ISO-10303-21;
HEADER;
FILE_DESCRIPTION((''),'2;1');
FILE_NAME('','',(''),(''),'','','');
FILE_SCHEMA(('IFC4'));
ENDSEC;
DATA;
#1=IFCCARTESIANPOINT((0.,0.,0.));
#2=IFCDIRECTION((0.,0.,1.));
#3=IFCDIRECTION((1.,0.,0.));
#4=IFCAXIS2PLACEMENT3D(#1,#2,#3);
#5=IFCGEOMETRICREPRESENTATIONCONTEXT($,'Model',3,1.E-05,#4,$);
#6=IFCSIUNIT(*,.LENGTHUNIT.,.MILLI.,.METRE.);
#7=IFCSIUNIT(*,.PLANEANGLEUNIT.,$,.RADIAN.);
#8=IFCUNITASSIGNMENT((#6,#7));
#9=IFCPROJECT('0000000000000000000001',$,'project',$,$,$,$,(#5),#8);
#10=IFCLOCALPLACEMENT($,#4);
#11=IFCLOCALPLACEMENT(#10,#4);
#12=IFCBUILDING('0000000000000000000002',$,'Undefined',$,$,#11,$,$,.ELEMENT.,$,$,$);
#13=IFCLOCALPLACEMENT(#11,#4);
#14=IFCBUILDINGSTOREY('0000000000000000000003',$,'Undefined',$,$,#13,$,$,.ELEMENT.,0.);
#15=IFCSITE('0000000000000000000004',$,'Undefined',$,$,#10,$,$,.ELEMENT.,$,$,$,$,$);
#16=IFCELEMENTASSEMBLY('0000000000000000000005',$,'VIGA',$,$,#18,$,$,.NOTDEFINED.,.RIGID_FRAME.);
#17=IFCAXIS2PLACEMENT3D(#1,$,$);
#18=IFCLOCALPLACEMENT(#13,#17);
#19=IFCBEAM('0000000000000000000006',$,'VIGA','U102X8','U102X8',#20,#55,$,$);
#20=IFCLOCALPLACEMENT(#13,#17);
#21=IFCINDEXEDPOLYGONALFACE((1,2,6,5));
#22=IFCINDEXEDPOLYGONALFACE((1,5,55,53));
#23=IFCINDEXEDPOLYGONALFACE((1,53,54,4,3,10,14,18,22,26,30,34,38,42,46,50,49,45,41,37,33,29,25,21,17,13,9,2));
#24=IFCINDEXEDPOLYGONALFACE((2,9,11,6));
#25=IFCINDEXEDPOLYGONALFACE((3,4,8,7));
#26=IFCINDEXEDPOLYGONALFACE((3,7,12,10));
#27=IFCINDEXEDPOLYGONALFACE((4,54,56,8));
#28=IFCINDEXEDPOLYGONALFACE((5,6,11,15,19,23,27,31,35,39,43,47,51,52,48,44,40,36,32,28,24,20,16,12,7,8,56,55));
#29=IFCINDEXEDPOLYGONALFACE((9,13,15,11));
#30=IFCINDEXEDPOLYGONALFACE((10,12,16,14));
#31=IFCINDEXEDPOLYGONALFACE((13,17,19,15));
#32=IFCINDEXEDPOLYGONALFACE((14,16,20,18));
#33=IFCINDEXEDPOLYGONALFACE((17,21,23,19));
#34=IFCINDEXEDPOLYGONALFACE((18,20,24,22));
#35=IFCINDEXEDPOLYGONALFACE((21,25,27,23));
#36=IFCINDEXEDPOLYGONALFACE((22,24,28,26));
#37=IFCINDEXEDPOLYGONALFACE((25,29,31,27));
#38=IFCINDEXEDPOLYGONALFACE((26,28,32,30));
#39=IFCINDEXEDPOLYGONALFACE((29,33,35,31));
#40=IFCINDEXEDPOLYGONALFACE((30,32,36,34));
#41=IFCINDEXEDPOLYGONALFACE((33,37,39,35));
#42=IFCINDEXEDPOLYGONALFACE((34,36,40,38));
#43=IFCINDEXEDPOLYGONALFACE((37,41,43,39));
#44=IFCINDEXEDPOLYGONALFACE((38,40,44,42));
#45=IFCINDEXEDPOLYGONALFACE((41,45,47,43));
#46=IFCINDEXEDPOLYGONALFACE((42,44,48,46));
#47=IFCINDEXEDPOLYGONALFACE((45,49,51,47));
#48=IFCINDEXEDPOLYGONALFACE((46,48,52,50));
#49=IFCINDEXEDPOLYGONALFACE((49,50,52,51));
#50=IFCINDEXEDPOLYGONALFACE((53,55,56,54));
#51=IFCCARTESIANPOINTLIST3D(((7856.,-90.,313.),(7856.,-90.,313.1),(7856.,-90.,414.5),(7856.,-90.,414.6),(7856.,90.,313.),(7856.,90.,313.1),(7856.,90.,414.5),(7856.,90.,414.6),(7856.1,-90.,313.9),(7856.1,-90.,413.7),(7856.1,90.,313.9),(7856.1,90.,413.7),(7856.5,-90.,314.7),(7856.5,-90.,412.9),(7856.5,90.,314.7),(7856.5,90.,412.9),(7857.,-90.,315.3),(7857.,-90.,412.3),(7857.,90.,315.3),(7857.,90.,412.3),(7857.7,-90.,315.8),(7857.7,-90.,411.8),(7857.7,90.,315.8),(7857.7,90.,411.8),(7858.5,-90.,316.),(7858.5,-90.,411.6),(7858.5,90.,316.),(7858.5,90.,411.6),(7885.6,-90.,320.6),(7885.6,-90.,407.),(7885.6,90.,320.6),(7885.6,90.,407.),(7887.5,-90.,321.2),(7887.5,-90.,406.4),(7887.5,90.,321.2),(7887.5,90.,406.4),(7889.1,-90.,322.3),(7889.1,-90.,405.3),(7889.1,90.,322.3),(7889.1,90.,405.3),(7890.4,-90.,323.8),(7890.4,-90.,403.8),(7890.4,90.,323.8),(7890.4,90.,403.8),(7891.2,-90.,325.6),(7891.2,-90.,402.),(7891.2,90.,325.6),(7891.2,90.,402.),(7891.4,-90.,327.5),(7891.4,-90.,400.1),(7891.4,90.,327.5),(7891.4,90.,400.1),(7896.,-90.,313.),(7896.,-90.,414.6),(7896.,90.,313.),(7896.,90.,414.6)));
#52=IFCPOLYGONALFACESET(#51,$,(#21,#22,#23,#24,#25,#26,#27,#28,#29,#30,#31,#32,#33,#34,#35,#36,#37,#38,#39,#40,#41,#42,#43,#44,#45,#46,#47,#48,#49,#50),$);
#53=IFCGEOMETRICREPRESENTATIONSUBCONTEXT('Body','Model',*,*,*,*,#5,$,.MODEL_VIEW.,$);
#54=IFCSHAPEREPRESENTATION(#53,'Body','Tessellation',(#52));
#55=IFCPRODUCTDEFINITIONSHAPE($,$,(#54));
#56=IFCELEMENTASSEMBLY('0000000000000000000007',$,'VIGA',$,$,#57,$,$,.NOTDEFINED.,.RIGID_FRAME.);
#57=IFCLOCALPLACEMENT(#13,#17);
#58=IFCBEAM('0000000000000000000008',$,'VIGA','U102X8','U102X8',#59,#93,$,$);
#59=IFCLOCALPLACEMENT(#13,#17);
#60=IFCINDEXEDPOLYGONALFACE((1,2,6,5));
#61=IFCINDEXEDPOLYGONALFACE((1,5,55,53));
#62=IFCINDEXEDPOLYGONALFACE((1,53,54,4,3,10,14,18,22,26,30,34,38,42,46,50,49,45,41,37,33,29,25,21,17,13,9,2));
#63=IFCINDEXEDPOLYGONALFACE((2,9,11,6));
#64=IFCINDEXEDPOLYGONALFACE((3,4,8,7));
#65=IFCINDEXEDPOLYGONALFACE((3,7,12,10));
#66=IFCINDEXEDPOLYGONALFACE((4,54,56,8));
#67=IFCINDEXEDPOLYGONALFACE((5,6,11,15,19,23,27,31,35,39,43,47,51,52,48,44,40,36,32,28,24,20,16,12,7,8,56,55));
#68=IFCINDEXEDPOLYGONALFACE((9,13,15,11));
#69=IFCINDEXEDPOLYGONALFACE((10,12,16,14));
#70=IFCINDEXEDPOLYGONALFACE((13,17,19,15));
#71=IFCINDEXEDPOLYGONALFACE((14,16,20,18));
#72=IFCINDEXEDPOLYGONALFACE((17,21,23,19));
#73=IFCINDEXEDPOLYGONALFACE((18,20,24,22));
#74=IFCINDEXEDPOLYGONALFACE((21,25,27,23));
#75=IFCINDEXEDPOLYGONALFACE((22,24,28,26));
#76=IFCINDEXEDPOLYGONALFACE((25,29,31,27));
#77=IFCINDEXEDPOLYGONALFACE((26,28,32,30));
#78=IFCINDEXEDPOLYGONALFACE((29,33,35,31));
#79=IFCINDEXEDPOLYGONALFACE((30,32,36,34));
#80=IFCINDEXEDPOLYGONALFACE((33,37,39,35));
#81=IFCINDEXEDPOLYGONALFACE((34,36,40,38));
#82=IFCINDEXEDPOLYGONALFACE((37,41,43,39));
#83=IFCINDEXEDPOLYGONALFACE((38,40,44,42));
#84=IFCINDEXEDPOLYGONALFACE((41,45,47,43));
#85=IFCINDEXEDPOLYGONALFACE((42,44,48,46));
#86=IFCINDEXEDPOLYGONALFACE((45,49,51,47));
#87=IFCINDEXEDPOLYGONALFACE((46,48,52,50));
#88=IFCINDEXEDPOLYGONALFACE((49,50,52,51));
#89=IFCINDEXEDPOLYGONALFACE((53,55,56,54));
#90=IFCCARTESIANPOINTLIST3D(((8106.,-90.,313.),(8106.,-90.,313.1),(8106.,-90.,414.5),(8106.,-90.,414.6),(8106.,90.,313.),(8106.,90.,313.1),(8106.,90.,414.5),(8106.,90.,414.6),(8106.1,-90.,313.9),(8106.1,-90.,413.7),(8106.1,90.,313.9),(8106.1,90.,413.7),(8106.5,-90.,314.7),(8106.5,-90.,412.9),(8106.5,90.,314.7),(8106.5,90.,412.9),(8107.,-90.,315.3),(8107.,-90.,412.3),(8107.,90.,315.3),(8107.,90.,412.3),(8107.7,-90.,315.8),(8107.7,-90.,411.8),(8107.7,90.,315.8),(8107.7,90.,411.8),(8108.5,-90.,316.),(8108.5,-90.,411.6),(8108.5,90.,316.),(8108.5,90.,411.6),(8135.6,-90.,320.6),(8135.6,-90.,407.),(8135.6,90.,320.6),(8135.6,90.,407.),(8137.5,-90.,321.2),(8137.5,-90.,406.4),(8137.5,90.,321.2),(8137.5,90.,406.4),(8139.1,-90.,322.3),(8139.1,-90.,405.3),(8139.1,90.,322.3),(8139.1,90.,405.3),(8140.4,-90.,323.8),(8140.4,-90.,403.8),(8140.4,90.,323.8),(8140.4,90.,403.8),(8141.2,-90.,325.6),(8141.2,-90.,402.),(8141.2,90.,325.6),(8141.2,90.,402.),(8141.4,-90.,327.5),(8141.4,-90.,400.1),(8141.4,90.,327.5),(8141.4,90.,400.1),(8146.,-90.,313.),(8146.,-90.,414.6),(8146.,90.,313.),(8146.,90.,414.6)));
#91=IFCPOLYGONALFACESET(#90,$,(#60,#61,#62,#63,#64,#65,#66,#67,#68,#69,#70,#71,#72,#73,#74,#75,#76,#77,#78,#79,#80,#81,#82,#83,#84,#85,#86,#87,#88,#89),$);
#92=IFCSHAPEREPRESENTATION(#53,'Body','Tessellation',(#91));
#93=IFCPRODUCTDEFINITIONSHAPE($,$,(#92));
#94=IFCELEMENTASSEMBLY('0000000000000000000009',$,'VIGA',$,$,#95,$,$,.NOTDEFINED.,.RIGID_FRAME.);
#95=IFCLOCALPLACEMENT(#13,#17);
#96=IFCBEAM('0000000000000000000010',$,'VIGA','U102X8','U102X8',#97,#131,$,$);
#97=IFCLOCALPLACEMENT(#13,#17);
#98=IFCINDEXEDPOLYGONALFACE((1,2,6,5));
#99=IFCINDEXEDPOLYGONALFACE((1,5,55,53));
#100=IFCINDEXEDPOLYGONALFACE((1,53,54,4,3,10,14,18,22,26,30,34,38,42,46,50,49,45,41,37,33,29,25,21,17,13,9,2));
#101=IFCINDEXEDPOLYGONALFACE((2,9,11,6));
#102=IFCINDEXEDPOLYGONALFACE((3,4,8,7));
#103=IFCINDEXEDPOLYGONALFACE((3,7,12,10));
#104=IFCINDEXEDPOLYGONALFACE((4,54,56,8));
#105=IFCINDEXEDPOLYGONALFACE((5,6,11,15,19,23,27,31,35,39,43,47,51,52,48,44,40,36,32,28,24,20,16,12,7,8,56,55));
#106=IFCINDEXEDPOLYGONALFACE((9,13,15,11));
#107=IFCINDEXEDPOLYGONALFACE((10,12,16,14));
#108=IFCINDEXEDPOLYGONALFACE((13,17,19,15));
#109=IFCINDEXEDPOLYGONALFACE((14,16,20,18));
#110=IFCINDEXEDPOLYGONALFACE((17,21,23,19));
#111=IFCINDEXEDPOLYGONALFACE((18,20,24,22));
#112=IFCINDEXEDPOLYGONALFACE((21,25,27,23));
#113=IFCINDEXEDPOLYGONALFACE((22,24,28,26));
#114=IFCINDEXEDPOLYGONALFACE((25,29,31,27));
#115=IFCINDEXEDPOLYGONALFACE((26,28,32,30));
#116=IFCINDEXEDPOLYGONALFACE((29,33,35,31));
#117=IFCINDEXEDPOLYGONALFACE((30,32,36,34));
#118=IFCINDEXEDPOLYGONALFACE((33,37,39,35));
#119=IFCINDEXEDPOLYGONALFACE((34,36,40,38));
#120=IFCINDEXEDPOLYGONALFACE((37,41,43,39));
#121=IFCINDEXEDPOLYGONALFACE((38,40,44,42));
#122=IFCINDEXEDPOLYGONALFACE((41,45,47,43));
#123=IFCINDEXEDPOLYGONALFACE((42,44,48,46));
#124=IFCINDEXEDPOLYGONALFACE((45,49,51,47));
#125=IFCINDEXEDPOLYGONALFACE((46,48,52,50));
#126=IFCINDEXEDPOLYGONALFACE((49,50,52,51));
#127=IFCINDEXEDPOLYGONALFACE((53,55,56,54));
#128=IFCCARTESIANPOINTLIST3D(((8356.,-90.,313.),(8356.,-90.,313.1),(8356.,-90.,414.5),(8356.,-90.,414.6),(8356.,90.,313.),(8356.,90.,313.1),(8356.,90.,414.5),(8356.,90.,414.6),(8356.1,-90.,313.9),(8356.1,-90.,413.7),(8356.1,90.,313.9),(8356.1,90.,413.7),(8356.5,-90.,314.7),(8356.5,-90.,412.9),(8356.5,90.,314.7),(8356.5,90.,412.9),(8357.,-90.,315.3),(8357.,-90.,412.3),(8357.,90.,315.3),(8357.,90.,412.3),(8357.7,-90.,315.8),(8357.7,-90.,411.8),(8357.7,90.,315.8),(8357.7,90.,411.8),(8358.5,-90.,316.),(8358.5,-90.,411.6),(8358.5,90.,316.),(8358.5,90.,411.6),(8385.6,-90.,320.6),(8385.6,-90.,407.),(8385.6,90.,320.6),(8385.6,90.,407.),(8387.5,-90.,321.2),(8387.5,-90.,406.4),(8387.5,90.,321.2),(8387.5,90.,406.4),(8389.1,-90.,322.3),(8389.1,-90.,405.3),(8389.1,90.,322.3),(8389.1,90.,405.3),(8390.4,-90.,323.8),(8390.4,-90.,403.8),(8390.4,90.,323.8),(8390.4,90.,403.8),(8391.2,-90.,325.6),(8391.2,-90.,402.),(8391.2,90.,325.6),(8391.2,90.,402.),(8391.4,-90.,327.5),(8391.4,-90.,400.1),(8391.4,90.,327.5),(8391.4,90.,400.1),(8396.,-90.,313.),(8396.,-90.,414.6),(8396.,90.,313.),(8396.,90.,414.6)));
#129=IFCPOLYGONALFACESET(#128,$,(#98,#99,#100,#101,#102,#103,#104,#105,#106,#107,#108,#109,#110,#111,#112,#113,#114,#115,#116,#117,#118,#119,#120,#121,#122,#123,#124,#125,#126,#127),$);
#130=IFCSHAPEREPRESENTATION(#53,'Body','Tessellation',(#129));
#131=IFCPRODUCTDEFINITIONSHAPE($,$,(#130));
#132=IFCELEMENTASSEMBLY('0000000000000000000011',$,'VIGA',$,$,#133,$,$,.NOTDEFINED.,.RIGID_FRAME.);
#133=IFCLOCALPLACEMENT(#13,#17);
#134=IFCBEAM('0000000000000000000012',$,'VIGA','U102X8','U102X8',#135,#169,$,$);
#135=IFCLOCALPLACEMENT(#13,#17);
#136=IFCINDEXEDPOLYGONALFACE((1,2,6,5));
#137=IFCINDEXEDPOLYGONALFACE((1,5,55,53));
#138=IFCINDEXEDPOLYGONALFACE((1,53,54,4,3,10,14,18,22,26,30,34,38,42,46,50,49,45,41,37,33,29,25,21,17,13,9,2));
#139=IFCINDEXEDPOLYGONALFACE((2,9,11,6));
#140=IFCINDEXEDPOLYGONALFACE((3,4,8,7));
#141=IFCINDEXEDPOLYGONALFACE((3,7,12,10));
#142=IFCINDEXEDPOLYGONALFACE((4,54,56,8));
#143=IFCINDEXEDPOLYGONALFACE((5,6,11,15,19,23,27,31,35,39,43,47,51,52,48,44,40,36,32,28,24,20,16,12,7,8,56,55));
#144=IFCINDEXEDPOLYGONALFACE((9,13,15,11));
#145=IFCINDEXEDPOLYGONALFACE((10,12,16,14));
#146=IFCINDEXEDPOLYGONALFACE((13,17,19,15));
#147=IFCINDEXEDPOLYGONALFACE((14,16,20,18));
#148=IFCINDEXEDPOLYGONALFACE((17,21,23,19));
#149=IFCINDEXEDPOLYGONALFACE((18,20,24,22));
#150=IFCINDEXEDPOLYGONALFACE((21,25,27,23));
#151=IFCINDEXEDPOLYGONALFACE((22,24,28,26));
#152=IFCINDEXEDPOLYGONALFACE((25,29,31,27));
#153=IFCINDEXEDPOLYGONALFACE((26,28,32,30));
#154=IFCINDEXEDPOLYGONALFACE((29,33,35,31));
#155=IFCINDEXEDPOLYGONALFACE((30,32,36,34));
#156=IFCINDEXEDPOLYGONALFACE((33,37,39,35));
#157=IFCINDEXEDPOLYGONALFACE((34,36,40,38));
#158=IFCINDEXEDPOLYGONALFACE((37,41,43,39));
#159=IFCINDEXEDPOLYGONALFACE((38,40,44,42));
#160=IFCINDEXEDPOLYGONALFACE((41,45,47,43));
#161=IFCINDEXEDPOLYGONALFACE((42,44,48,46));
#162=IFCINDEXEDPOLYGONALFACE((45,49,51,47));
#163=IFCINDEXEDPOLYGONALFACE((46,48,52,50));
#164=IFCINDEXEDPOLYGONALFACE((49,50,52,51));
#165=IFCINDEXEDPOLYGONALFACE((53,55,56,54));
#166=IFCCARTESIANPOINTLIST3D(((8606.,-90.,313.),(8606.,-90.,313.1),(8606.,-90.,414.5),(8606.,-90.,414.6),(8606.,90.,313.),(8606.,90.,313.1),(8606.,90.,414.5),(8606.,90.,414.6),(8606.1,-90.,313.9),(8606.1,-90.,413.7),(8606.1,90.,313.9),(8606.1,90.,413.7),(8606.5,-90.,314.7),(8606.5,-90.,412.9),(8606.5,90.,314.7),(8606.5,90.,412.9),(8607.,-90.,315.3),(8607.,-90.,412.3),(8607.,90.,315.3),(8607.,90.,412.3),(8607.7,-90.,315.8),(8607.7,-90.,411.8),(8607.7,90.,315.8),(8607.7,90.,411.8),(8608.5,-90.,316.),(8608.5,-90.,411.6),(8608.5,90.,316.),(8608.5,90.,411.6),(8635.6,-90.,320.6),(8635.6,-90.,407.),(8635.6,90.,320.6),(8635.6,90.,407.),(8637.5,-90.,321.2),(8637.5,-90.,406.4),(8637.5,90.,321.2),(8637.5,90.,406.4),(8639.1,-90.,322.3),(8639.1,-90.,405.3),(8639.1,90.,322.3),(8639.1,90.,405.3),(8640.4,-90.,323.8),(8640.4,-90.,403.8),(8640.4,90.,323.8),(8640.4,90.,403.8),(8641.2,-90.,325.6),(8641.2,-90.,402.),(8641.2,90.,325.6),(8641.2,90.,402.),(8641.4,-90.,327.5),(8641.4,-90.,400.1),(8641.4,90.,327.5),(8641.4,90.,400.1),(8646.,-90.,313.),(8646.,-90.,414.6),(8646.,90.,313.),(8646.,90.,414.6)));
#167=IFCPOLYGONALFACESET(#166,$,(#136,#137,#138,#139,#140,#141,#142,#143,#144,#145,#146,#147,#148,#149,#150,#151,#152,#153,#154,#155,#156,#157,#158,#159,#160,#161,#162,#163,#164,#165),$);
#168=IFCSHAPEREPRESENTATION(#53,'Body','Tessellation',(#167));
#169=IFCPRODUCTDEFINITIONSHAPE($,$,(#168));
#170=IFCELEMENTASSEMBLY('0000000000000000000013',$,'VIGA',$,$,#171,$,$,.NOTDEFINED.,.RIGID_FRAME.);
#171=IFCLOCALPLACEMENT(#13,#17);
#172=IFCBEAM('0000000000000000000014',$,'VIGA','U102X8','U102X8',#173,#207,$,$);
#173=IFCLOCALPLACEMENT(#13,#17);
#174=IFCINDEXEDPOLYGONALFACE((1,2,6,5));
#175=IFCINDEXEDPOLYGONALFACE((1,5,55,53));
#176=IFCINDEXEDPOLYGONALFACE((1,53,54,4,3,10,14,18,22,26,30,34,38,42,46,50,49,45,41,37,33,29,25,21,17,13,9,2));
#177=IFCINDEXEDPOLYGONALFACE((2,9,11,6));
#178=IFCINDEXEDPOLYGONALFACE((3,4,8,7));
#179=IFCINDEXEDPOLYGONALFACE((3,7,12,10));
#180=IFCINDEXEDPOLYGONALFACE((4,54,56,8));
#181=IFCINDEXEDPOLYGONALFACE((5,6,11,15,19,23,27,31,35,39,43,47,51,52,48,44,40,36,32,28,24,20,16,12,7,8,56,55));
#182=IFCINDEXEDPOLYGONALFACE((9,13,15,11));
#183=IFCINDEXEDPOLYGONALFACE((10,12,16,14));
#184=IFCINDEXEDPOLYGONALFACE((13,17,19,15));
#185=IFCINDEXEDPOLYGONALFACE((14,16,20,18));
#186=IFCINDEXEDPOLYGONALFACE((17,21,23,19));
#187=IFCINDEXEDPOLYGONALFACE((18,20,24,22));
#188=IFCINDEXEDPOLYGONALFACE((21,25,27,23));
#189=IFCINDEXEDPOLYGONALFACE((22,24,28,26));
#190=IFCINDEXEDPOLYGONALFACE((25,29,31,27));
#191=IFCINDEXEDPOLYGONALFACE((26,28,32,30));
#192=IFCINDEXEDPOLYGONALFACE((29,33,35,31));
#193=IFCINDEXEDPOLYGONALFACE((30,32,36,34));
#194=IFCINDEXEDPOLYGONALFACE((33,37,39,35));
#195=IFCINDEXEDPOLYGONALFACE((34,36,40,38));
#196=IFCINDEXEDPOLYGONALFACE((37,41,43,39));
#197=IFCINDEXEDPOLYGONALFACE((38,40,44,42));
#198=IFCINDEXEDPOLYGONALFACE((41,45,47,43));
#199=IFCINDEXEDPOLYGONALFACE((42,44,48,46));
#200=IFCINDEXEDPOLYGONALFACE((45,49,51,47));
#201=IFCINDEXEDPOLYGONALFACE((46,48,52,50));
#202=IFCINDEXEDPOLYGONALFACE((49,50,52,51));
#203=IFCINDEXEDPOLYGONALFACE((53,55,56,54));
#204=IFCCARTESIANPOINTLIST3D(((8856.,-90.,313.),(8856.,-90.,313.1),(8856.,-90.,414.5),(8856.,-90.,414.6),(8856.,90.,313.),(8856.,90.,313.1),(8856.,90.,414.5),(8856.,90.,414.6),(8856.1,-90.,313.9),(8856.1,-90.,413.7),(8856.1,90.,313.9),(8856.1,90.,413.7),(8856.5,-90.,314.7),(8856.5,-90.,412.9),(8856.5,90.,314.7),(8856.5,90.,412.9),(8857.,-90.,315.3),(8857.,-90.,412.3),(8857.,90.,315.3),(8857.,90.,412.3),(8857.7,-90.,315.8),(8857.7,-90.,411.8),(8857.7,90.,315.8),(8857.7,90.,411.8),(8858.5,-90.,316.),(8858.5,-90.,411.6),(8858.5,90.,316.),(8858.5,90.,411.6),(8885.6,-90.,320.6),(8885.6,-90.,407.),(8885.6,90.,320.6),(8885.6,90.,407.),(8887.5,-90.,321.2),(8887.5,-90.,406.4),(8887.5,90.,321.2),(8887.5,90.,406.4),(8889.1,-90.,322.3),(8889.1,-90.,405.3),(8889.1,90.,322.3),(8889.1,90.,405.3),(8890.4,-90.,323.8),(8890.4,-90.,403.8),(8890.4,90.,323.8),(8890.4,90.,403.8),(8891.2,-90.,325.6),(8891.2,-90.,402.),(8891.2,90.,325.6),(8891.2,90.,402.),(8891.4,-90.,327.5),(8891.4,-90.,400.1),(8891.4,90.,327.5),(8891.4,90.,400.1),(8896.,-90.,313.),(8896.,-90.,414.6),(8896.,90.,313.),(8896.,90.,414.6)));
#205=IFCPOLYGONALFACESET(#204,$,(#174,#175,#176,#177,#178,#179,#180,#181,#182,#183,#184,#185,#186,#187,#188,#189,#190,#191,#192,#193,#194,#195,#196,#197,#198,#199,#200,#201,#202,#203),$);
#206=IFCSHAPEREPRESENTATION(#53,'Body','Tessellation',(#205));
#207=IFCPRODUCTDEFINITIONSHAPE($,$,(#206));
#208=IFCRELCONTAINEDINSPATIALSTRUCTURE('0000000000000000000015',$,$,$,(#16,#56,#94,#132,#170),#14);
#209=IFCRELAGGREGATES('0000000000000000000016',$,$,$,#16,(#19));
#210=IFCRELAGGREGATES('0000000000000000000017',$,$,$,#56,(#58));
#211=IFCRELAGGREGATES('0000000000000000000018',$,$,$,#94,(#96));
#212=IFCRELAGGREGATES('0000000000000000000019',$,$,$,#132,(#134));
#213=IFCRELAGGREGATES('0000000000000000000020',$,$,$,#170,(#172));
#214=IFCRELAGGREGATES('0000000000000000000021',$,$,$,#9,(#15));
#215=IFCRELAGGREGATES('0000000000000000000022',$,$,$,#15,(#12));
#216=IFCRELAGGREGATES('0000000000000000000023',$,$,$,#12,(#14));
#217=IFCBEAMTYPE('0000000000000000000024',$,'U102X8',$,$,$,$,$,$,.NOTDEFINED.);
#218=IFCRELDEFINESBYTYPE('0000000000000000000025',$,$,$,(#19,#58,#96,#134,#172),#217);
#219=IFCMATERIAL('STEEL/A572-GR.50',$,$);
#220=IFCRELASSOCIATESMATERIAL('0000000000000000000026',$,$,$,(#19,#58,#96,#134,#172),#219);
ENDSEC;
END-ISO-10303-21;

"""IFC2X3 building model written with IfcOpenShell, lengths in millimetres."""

from ifc_helpers import new_model, si_unit, frame, origin_with_axes, origin_2d_with_axis, place, context, subcontext, project, spatial, u_section, extrude, material, type_object, element, aggregate, save


model = new_model("IFC2X3")

# Units and contexts
model_context = context("Model", 3, precision=1e-05, world=origin_with_axes())
body_context = subcontext(model_context, "Body", "Model", "MODEL_VIEW")
ifc_project = project(units=[si_unit("LENGTHUNIT", "METRE", prefix="MILLI"), si_unit("PLANEANGLEUNIT", "RADIAN")], contexts=[model_context])

# Site, building, storey
site_placement = place(None, origin_with_axes())
site = spatial("IfcSite", under=ifc_project, at=site_placement, Name="Undefined", CompositionType="ELEMENT")
building_placement = place(site_placement, origin_with_axes())
building = spatial("IfcBuilding", under=site, at=building_placement, Name="Undefined", CompositionType="ELEMENT")
storey_placement = place(building_placement, origin_with_axes())
storey = spatial("IfcBuildingStorey", under=building, at=storey_placement, Name="Undefined", CompositionType="ELEMENT", Elevation=0.0)

# Element assemblies, beams
ifc_material_1 = material(Name="STEEL/A572-GR.50")
beam_type = type_object("IfcBeamType", Name="U102X8", PredefinedType="NOTDEFINED")
assembly_1_placement = place(storey_placement, origin_with_axes())
assembly_1 = element("IfcElementAssembly", 1, at=assembly_1_placement, inside=storey, Name="VIGA", AssemblyPlace="NOTDEFINED", PredefinedType="RIGID_FRAME")
beam_1_placement = place(assembly_1_placement, frame((7876.0, 90.0, 363.8), z_axis=(0.0, 0.0, 1.0), x_axis=(0.0, -1.0, 0.0)))
beam_1 = element("IfcBeam", 2, at=beam_1_placement, type_object=beam_type, material=ifc_material_1, Name="VIGA", Description="U102X8", ObjectType="U102X8", context=body_context, shape_type="SweptSolid", body=[
    extrude(u_section(Depth=101.6, FlangeWidth=40.0, WebThickness=4.6, FlangeThickness=6.0, FilletRadius=7.0, EdgeRadius=3.0, FlangeSlope=0.16839, at=origin_2d_with_axis()), frame((180.0, 0.0, 0.0), z_axis=(-1.0, 0.0, 0.0), x_axis=(0.0, -1.0, 0.0)), (0.0, 0.0, 1.0), 180.0),
])
aggregate(assembly_1, [beam_1])
assembly_2_placement = place(storey_placement, origin_with_axes())
assembly_2 = element("IfcElementAssembly", 3, at=assembly_2_placement, inside=storey, Name="VIGA", AssemblyPlace="NOTDEFINED", PredefinedType="RIGID_FRAME")
beam_2_placement = place(assembly_2_placement, frame((8126.0, 90.0, 363.8), z_axis=(0.0, 0.0, 1.0), x_axis=(0.0, -1.0, 0.0)))
beam_2 = element("IfcBeam", 4, at=beam_2_placement, type_object=beam_type, material=ifc_material_1, Name="VIGA", Description="U102X8", ObjectType="U102X8", context=body_context, shape_type="SweptSolid", body=[
    extrude(u_section(Depth=101.6, FlangeWidth=40.0, WebThickness=4.6, FlangeThickness=6.0, FilletRadius=7.0, EdgeRadius=3.0, FlangeSlope=0.16839, at=origin_2d_with_axis()), frame((180.0, 0.0, 0.0), z_axis=(-1.0, 0.0, 0.0), x_axis=(0.0, -1.0, 0.0)), (0.0, 0.0, 1.0), 180.0),
])
aggregate(assembly_2, [beam_2])
assembly_3_placement = place(storey_placement, origin_with_axes())
assembly_3 = element("IfcElementAssembly", 5, at=assembly_3_placement, inside=storey, Name="VIGA", AssemblyPlace="NOTDEFINED", PredefinedType="RIGID_FRAME")
beam_3_placement = place(assembly_3_placement, frame((8376.0, 90.0, 363.8), z_axis=(0.0, 0.0, 1.0), x_axis=(0.0, -1.0, 0.0)))
beam_3 = element("IfcBeam", 6, at=beam_3_placement, type_object=beam_type, material=ifc_material_1, Name="VIGA", Description="U102X8", ObjectType="U102X8", context=body_context, shape_type="SweptSolid", body=[
    extrude(u_section(Depth=101.6, FlangeWidth=40.0, WebThickness=4.6, FlangeThickness=6.0, FilletRadius=7.0, EdgeRadius=3.0, FlangeSlope=0.16839, at=origin_2d_with_axis()), frame((180.0, 0.0, 0.0), z_axis=(-1.0, 0.0, 0.0), x_axis=(0.0, -1.0, 0.0)), (0.0, 0.0, 1.0), 180.0),
])
aggregate(assembly_3, [beam_3])
assembly_4_placement = place(storey_placement, origin_with_axes())
assembly_4 = element("IfcElementAssembly", 7, at=assembly_4_placement, inside=storey, Name="VIGA", AssemblyPlace="NOTDEFINED", PredefinedType="RIGID_FRAME")
beam_4_placement = place(assembly_4_placement, frame((8626.0, 90.0, 363.8), z_axis=(0.0, 0.0, 1.0), x_axis=(0.0, -1.0, 0.0)))
beam_4 = element("IfcBeam", 8, at=beam_4_placement, type_object=beam_type, material=ifc_material_1, Name="VIGA", Description="U102X8", ObjectType="U102X8", context=body_context, shape_type="SweptSolid", body=[
    extrude(u_section(Depth=101.6, FlangeWidth=40.0, WebThickness=4.6, FlangeThickness=6.0, FilletRadius=7.0, EdgeRadius=3.0, FlangeSlope=0.16839, at=origin_2d_with_axis()), frame((180.0, 0.0, 0.0), z_axis=(-1.0, 0.0, 0.0), x_axis=(0.0, -1.0, 0.0)), (0.0, 0.0, 1.0), 180.0),
])
aggregate(assembly_4, [beam_4])
assembly_5_placement = place(storey_placement, origin_with_axes())
assembly_5 = element("IfcElementAssembly", 9, at=assembly_5_placement, inside=storey, Name="VIGA", AssemblyPlace="NOTDEFINED", PredefinedType="RIGID_FRAME")
beam_5_placement = place(assembly_5_placement, frame((8876.0, 90.0, 363.8), z_axis=(0.0, 0.0, 1.0), x_axis=(0.0, -1.0, 0.0)))
beam_5 = element("IfcBeam", 10, at=beam_5_placement, type_object=beam_type, material=ifc_material_1, Name="VIGA", Description="U102X8", ObjectType="U102X8", context=body_context, shape_type="SweptSolid", body=[
    extrude(u_section(Depth=101.6, FlangeWidth=40.0, WebThickness=4.6, FlangeThickness=6.0, FilletRadius=7.0, EdgeRadius=3.0, FlangeSlope=0.16839, at=origin_2d_with_axis()), frame((180.0, 0.0, 0.0), z_axis=(-1.0, 0.0, 0.0), x_axis=(0.0, -1.0, 0.0)), (0.0, 0.0, 1.0), 180.0),
])
aggregate(assembly_5, [beam_5])

save(model, "model.ifc")
